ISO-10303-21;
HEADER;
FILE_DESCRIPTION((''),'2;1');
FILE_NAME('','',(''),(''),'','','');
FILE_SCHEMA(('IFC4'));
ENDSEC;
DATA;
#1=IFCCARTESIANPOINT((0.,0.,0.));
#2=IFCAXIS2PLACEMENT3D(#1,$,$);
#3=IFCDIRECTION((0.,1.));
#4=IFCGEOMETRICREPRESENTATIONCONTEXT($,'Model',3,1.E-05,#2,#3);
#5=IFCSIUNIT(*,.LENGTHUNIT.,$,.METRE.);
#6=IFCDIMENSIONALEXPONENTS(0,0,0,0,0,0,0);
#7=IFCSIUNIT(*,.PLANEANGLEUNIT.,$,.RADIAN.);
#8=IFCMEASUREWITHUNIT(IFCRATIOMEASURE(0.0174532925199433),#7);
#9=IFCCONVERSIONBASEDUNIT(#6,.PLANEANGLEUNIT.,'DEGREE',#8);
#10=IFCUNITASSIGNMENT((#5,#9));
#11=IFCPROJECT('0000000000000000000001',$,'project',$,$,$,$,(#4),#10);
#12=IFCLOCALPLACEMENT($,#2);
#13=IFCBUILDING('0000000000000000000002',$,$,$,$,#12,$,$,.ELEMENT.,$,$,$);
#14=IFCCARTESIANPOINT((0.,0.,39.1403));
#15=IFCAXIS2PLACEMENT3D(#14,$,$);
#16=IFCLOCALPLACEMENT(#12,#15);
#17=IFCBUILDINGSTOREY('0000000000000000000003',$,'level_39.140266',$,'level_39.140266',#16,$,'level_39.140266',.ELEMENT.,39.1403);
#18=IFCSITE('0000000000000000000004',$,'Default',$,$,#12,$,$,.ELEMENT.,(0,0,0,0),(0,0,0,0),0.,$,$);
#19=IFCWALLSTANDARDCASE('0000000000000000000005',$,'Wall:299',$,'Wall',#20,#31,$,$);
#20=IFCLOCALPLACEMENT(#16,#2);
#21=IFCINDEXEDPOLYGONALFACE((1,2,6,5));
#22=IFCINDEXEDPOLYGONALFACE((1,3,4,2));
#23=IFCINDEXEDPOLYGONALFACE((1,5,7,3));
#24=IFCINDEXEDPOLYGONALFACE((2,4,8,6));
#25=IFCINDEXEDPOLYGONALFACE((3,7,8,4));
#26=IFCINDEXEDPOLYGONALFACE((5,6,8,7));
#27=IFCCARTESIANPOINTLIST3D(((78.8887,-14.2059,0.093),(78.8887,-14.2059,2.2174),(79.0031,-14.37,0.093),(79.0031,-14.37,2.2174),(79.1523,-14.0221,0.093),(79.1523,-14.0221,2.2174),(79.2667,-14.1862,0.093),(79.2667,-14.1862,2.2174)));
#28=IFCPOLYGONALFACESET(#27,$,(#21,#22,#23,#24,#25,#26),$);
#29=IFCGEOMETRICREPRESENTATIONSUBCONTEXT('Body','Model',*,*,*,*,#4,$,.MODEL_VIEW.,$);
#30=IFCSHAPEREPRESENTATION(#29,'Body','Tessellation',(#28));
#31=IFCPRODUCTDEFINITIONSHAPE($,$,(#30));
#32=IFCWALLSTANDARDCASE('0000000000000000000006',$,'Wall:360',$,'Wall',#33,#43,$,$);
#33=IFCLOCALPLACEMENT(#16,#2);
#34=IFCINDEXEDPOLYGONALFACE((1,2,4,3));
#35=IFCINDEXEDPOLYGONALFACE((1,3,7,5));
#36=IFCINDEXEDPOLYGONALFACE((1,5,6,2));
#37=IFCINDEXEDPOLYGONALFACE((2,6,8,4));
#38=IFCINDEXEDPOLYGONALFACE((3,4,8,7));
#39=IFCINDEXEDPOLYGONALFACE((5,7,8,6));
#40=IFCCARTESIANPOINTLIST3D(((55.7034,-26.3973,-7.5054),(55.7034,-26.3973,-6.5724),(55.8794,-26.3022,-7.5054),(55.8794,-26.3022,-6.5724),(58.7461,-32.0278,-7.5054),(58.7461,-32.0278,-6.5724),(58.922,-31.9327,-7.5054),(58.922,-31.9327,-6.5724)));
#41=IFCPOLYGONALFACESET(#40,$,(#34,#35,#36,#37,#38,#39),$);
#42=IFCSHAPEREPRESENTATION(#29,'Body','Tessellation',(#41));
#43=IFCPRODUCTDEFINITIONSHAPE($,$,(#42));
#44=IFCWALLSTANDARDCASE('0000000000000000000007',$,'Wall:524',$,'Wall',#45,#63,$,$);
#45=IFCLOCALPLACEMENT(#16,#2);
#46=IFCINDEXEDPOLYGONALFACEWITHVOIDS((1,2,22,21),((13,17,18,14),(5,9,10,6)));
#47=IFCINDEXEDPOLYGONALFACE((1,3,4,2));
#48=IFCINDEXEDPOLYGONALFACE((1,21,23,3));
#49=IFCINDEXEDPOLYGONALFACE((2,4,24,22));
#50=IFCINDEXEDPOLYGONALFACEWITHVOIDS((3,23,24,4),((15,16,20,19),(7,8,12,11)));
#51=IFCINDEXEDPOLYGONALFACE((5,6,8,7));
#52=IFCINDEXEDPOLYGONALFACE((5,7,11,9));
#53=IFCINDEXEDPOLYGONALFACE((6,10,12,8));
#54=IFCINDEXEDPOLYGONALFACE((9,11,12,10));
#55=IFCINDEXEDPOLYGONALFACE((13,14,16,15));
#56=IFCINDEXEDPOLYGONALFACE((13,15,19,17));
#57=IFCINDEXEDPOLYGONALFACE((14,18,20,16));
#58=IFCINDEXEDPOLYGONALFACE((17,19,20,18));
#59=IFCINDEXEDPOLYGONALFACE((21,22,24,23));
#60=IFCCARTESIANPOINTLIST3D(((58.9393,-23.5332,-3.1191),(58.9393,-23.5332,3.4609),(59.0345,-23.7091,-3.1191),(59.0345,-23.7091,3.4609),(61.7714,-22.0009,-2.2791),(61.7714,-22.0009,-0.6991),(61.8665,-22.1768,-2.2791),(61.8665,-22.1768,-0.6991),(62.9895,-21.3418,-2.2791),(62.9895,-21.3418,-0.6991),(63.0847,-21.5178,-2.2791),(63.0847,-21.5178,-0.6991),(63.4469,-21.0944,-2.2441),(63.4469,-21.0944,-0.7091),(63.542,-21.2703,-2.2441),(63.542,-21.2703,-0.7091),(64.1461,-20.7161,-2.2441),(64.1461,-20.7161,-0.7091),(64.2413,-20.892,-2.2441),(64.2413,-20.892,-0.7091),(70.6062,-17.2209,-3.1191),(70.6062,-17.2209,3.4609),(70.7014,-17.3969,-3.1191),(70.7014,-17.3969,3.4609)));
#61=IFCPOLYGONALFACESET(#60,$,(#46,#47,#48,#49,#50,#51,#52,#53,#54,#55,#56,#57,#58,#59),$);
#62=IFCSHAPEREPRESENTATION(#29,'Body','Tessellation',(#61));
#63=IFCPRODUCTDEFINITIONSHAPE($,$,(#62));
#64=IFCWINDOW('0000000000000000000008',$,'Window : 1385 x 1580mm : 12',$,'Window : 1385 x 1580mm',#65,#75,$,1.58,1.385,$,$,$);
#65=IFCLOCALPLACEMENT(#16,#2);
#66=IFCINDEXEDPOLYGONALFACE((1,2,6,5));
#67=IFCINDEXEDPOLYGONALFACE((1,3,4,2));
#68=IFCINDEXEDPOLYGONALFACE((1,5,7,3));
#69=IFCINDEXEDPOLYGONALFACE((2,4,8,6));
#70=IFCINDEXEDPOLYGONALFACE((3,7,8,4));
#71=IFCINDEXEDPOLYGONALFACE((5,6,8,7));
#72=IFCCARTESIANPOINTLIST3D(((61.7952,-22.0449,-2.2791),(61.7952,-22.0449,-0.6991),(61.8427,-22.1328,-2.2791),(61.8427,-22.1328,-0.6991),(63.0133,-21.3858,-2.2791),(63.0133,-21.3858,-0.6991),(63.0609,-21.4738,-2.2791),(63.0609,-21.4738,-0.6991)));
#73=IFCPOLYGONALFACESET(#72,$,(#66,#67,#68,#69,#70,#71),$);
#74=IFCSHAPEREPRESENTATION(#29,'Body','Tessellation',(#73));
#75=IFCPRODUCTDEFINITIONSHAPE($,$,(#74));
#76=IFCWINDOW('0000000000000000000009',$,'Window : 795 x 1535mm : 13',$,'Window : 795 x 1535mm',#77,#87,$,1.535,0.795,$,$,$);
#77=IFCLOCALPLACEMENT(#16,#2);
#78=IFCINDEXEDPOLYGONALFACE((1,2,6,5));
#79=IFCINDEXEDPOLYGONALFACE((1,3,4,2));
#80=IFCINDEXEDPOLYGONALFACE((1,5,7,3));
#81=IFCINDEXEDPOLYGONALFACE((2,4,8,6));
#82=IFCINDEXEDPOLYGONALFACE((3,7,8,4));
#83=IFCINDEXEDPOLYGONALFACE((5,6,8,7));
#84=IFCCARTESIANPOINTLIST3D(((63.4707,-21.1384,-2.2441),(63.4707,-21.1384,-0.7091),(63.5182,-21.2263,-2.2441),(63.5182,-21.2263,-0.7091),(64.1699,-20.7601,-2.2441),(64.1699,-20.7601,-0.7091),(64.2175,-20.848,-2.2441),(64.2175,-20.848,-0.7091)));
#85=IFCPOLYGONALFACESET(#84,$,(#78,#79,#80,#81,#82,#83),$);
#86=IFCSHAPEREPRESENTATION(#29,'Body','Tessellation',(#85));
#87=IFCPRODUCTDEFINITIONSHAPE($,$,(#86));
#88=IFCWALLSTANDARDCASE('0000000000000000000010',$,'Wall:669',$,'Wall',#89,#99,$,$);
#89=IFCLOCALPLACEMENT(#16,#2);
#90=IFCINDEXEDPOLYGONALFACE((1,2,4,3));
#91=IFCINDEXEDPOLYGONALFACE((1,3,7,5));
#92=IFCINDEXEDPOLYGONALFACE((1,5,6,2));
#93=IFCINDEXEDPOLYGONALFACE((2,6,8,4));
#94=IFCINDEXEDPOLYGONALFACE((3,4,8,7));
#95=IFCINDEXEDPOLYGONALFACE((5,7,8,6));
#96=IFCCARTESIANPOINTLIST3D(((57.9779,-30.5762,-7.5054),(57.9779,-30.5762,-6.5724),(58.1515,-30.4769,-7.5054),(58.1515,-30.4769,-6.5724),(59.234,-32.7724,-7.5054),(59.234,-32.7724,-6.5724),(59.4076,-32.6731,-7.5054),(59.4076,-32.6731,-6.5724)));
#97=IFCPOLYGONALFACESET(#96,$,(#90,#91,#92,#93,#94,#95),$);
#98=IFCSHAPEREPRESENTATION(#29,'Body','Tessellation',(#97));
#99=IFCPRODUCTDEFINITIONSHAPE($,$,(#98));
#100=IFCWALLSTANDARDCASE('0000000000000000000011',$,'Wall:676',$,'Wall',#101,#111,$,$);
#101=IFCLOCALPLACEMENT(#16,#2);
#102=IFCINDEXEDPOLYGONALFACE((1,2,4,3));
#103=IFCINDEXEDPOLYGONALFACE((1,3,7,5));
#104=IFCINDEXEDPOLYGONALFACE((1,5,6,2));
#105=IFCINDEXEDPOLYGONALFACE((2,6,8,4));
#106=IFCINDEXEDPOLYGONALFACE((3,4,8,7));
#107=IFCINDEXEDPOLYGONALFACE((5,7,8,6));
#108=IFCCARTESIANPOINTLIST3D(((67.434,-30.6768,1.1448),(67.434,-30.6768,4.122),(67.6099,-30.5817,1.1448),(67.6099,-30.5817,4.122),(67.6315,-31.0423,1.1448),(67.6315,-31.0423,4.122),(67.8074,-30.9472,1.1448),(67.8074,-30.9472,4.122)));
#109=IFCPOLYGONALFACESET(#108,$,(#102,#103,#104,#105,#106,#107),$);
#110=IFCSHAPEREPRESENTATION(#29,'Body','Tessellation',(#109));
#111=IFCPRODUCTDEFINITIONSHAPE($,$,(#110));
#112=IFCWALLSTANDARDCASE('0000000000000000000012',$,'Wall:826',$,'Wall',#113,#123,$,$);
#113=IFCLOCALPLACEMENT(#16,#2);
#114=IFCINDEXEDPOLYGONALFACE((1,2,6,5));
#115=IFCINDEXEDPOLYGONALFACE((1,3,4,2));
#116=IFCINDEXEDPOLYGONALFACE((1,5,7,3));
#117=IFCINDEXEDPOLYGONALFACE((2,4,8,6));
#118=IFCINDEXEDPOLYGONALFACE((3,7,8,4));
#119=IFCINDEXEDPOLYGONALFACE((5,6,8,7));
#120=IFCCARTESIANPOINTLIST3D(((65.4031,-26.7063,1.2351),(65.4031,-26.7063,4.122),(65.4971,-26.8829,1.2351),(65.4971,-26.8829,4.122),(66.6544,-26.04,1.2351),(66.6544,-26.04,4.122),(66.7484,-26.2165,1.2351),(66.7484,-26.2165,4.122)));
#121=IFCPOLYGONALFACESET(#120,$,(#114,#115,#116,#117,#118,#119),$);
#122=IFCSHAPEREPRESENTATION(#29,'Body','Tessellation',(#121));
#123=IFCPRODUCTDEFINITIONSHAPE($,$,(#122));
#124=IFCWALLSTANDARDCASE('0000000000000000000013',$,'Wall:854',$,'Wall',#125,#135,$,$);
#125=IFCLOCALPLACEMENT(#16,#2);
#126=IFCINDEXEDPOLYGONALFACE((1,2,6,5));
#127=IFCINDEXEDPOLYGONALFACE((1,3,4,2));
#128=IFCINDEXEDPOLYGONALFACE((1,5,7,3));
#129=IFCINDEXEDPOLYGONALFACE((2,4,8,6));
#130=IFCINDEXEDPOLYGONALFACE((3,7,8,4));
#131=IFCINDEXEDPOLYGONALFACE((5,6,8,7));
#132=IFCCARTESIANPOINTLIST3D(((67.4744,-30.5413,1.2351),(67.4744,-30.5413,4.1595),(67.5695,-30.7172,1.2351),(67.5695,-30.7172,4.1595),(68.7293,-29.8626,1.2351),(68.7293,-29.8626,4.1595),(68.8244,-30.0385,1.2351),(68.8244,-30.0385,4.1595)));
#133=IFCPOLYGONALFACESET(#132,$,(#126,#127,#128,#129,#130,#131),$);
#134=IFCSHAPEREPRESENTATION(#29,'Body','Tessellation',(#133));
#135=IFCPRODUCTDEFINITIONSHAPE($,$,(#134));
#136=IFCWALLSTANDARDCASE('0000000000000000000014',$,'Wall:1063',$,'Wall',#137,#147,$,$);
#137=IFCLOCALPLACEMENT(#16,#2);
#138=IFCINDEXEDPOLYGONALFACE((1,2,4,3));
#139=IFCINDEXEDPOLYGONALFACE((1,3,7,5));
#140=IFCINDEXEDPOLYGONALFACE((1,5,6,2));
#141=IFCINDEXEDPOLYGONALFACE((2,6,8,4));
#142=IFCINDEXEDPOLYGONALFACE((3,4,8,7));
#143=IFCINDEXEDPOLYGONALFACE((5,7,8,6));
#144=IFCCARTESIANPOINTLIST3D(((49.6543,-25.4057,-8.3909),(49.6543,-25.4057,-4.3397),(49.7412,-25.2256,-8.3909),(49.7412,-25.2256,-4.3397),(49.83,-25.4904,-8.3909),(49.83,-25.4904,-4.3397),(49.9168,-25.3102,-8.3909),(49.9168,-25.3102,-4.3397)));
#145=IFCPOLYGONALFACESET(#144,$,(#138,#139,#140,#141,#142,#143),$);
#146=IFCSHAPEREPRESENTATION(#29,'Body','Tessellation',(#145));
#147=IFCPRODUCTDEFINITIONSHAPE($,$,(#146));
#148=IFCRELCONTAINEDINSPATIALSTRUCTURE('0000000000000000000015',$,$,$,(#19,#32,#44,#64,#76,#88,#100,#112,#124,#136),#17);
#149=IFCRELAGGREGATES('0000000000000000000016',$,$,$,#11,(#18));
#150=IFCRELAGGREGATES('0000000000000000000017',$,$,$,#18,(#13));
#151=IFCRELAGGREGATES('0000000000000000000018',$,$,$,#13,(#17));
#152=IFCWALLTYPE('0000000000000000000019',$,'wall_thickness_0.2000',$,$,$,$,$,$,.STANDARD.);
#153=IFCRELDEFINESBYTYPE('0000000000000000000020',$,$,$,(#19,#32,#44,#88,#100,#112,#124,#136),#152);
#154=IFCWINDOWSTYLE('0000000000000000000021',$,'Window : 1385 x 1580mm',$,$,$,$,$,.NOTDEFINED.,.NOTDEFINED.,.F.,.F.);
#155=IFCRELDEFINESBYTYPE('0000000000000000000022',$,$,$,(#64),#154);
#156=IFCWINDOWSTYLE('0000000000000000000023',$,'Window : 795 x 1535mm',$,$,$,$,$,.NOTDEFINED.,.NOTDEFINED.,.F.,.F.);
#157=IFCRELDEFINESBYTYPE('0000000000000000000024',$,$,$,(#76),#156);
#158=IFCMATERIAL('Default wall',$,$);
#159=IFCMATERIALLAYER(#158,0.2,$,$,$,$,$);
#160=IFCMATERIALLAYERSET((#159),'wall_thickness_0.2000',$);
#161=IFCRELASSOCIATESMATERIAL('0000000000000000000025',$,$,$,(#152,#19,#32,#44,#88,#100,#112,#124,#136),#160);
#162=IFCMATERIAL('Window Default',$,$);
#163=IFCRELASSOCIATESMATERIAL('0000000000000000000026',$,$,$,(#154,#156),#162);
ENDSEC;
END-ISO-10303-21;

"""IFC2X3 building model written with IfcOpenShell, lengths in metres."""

from ifc_helpers import new_model, entity, si_unit, converted_unit, direction, frame, frame_2d, origin, origin_2d_with_axis, place, context, subcontext, project, spatial, polyline, rectangle, outline, extrude, source, transform, mapped, material, layer, layer_set, layer_usage, type_object, type_shapes, element, fill, save


model = new_model("IFC2X3")

# Units and contexts
model_context = context("Model", 3, precision=1e-05, world=origin(), true_north=direction((0.0, 1.0)))
body_context = subcontext(model_context, "Body", "Model", "MODEL_VIEW")
ifc_project = project(units=[si_unit("LENGTHUNIT", "METRE"), converted_unit("PLANEANGLEUNIT", "DEGREE", entity("IfcRatioMeasure", 0.0174532925199433), si_unit("PLANEANGLEUNIT", "RADIAN"), dimensions=[0, 0, 0, 0, 0, 0, 0])], contexts=[model_context])

# Site, building, storey
placement_1 = place(None, origin())
site = spatial("IfcSite", under=ifc_project, at=placement_1, Name="Default", CompositionType="ELEMENT", RefLatitude=(0, 0, 0, 0), RefLongitude=(0, 0, 0, 0), RefElevation=0.0)
building = spatial("IfcBuilding", under=site, at=placement_1, CompositionType="ELEMENT")
storey_placement = place(placement_1, frame((0.0, 0.0, 39.1403)))
storey = spatial("IfcBuildingStorey", under=building, at=storey_placement, Name="level_39.140266", ObjectType="level_39.140266", LongName="level_39.140266", CompositionType="ELEMENT", Elevation=39.1403)

# Walls
ifc_material_1 = material(Name="Default wall")
ifc_layer = layer(ifc_material_1, 0.2)
ifc_layer_set = layer_set([ifc_layer], Name="wall_thickness_0.2000")
ifc_layer_usage = layer_usage(ifc_layer_set, "AXIS2", "POSITIVE", -0.1)
wall_type = type_object("IfcWallType", Name="wall_thickness_0.2000", PredefinedType="STANDARD", material=ifc_layer_set)
placement_2 = place(placement_1, frame((0.0, 0.0, 39.2333)))
wall_1_placement = place(placement_2, frame((78.9459, -14.2879, 0.0), z_axis=(0.0, 0.0, 1.0), x_axis=(0.820274, 0.571971, 0.0)))
element("IfcWallStandardCase", 1, at=wall_1_placement, inside=storey, type_object=wall_type, material=ifc_layer_usage, Name="Wall:299", ObjectType="Wall", context=body_context, shape_type="SweptSolid", body=[
    extrude(outline(polyline([(0.3213, -0.1), (0.3213, 0.1), (0.0, 0.1), (0.0, -0.1), (0.3213, -0.1)])), origin(), (0.0, 0.0, 1.0), 2.1244),
])
placement_3 = place(placement_1, frame((0.0, 0.0, 31.6349)))
wall_2_placement = place(placement_3, frame((55.7914, -26.3497, 0.0), z_axis=(0.0, 0.0, 1.0), x_axis=(0.475412, -0.879763, 0.0)))
element("IfcWallStandardCase", 2, at=wall_2_placement, inside=storey, type_object=wall_type, material=ifc_layer_usage, Name="Wall:360", ObjectType="Wall", context=body_context, shape_type="SweptSolid", body=[
    extrude(outline(polyline([(6.4, -0.1), (6.4, 0.1), (0.0, 0.1), (0.0, -0.1), (6.4, -0.1)])), origin(), (0.0, 0.0, 1.0), 0.9331),
])

# Wall, openings, windows
placement_4 = place(placement_1, frame((0.0, 0.0, 36.0212)))
wall_3_placement = place(placement_4, frame((58.9869, -23.6211, 0.0), z_axis=(0.0, 0.0, 1.0), x_axis=(0.879524, 0.475854, 0.0)))
wall_3 = element("IfcWallStandardCase", 3, at=wall_3_placement, inside=storey, type_object=wall_type, material=ifc_layer_usage, Name="Wall:524", ObjectType="Wall", context=body_context, shape_type="SweptSolid", body=[
    extrude(outline(polyline([(13.265, -0.1), (13.265, 0.1), (0.0, 0.1), (0.0, -0.1), (13.265, -0.1)])), origin(), (0.0, 0.0, 1.0), 6.58),
])
opening_1_placement = place(wall_3_placement, frame((3.22, -0.1, 0.84)))
opening_1 = element("IfcOpeningElement", 4, at=opening_1_placement, cuts=wall_3, ObjectType="Opening", context=body_context, shape_type="SweptSolid", body=[
    extrude(rectangle(XDim=1.385, YDim=1.58, at=frame_2d((0.79, 0.6925), x_axis=(0.0, 1.0))), frame((0.0, 0.0, 0.0), z_axis=(0.0, 1.0, 0.0), x_axis=(0.0, 0.0, 1.0)), (0.0, 0.0, 1.0), 0.2),
])
opening_2_placement = place(wall_3_placement, frame((5.125, -0.1, 0.875)))
opening_2 = element("IfcOpeningElement", 5, at=opening_2_placement, cuts=wall_3, ObjectType="Opening", context=body_context, shape_type="SweptSolid", body=[
    extrude(rectangle(XDim=0.795, YDim=1.535, at=frame_2d((0.7675, 0.3975), x_axis=(0.0, 1.0))), frame((0.0, 0.0, 0.0), z_axis=(0.0, 1.0, 0.0), x_axis=(0.0, 0.0, 1.0)), (0.0, 0.0, 1.0), 0.2),
])
ifc_material_2 = material(Name="Window Default")
window_style_1 = type_object("IfcWindowStyle", Name="Window : 1385 x 1580mm", ConstructionType="NOTDEFINED", OperationType="NOTDEFINED", ParameterTakesPrecedence=False, Sizeable=False, material=ifc_material_2)
shared_shape_1 = source(origin(), body_context, "Body", "SweptSolid", [
    extrude(rectangle(XDim=0.1, YDim=1.385, at=origin_2d_with_axis()), frame((0.6925, 0.1, 0.0), z_axis=(0.0, 0.0, 1.0), x_axis=(0.0, 1.0, 0.0)), (0.0, 0.0, 1.0), 1.58),
])
type_shapes(window_style_1, [shared_shape_1])
window_1_placement = place(opening_1_placement, origin())
window_1 = element("IfcWindow", 6, at=window_1_placement, inside=storey, type_object=window_style_1, Name="Window : 1385 x 1580mm : 12", ObjectType="Window : 1385 x 1580mm", OverallHeight=1.58, OverallWidth=1.385, context=body_context, shape_type="MappedRepresentation", body=[
    mapped(shared_shape_1, transform((0.0, 0.0, 0.0), scale=1.0)),
])
fill(opening_1, window_1)
window_style_2 = type_object("IfcWindowStyle", Name="Window : 795 x 1535mm", ConstructionType="NOTDEFINED", OperationType="NOTDEFINED", ParameterTakesPrecedence=False, Sizeable=False, material=ifc_material_2)
shared_shape_2 = source(origin(), body_context, "Body", "SweptSolid", [
    extrude(rectangle(XDim=0.1, YDim=0.795, at=origin_2d_with_axis()), frame((0.3975, 0.1, 0.0), z_axis=(0.0, 0.0, 1.0), x_axis=(0.0, 1.0, 0.0)), (0.0, 0.0, 1.0), 1.535),
])
type_shapes(window_style_2, [shared_shape_2])
window_2_placement = place(opening_2_placement, origin())
window_2 = element("IfcWindow", 7, at=window_2_placement, inside=storey, type_object=window_style_2, Name="Window : 795 x 1535mm : 13", ObjectType="Window : 795 x 1535mm", OverallHeight=1.535, OverallWidth=0.795, context=body_context, shape_type="MappedRepresentation", body=[
    mapped(shared_shape_2, transform((0.0, 0.0, 0.0), scale=1.0)),
])
fill(opening_2, window_2)

# Walls
placement_5 = place(placement_1, frame((0.0, 0.0, 31.6349)))
wall_4_placement = place(placement_5, frame((58.0647, -30.5266, 0.0), z_axis=(0.0, 0.0, 1.0), x_axis=(0.496489, -0.868043, 0.0)))
element("IfcWallStandardCase", 8, at=wall_4_placement, inside=storey, type_object=wall_type, material=ifc_layer_usage, Name="Wall:669", ObjectType="Wall", context=body_context, shape_type="SweptSolid", body=[
    extrude(outline(polyline([(2.53, -0.1), (2.53, 0.1), (0.0, 0.1), (0.0, -0.1), (2.53, -0.1)])), origin(), (0.0, 0.0, 1.0), 0.9331),
])
placement_6 = place(placement_1, frame((0.0, 0.0, 40.2851)))
wall_5_placement = place(placement_6, frame((67.7194, -30.9947, 0.0), z_axis=(0.0, 0.0, 1.0), x_axis=(-0.47548, 0.879727, 0.0)))
element("IfcWallStandardCase", 9, at=wall_5_placement, inside=storey, type_object=wall_type, material=ifc_layer_usage, Name="Wall:676", ObjectType="Wall", context=body_context, shape_type="SweptSolid", body=[
    extrude(outline(polyline([(0.4154, -0.1), (0.4154, 0.1), (0.0, 0.1), (0.0, -0.1), (0.4154, -0.1)])), origin(), (0.0, 0.0, 1.0), 2.9773),
])
placement_7 = place(placement_1, frame((0.0, 0.0, 40.3754)))
wall_6_placement = place(placement_7, frame((66.7014, -26.1283, 0.0), z_axis=(0.0, 0.0, 1.0), x_axis=(-0.882647, -0.470036, 0.0)))
element("IfcWallStandardCase", 10, at=wall_6_placement, inside=storey, type_object=wall_type, material=ifc_layer_usage, Name="Wall:826", ObjectType="Wall", context=body_context, shape_type="SweptSolid", body=[
    extrude(outline(polyline([(1.4176, -0.1), (1.4176, 0.1), (0.0, 0.1), (0.0, -0.1), (1.4176, -0.1)])), origin(), (0.0, 0.0, 1.0), 2.887),
])
placement_8 = place(placement_1, frame((0.0, 0.0, 40.3754)))
wall_7_placement = place(placement_8, frame((68.7768, -29.9506, 0.0), z_axis=(0.0, 0.0, 1.0), x_axis=(-0.879602, -0.47571, 0.0)))
element("IfcWallStandardCase", 11, at=wall_7_placement, inside=storey, type_object=wall_type, material=ifc_layer_usage, Name="Wall:854", ObjectType="Wall", context=body_context, shape_type="SweptSolid", body=[
    extrude(outline(polyline([(1.4267, -0.1), (1.4267, 0.1), (0.0, 0.1), (0.0, -0.1), (1.4267, -0.1)])), origin(), (0.0, 0.0, 1.0), 2.9244),
])
placement_9 = place(placement_1, frame((0.0, 0.0, 30.7494)))
wall_8_placement = place(placement_9, frame((49.8734, -25.4003, 0.0), z_axis=(0.0, 0.0, 1.0), x_axis=(-0.900783, 0.43427, 0.0)))
element("IfcWallStandardCase", 12, at=wall_8_placement, inside=storey, type_object=wall_type, material=ifc_layer_usage, Name="Wall:1063", ObjectType="Wall", context=body_context, shape_type="SweptSolid", body=[
    extrude(outline(polyline([(0.195, -0.1), (0.195, 0.1), (0.0, 0.1), (0.0, -0.1), (0.195, -0.1)])), origin(), (0.0, 0.0, 1.0), 4.0512),
])

save(model, "model.ifc")
